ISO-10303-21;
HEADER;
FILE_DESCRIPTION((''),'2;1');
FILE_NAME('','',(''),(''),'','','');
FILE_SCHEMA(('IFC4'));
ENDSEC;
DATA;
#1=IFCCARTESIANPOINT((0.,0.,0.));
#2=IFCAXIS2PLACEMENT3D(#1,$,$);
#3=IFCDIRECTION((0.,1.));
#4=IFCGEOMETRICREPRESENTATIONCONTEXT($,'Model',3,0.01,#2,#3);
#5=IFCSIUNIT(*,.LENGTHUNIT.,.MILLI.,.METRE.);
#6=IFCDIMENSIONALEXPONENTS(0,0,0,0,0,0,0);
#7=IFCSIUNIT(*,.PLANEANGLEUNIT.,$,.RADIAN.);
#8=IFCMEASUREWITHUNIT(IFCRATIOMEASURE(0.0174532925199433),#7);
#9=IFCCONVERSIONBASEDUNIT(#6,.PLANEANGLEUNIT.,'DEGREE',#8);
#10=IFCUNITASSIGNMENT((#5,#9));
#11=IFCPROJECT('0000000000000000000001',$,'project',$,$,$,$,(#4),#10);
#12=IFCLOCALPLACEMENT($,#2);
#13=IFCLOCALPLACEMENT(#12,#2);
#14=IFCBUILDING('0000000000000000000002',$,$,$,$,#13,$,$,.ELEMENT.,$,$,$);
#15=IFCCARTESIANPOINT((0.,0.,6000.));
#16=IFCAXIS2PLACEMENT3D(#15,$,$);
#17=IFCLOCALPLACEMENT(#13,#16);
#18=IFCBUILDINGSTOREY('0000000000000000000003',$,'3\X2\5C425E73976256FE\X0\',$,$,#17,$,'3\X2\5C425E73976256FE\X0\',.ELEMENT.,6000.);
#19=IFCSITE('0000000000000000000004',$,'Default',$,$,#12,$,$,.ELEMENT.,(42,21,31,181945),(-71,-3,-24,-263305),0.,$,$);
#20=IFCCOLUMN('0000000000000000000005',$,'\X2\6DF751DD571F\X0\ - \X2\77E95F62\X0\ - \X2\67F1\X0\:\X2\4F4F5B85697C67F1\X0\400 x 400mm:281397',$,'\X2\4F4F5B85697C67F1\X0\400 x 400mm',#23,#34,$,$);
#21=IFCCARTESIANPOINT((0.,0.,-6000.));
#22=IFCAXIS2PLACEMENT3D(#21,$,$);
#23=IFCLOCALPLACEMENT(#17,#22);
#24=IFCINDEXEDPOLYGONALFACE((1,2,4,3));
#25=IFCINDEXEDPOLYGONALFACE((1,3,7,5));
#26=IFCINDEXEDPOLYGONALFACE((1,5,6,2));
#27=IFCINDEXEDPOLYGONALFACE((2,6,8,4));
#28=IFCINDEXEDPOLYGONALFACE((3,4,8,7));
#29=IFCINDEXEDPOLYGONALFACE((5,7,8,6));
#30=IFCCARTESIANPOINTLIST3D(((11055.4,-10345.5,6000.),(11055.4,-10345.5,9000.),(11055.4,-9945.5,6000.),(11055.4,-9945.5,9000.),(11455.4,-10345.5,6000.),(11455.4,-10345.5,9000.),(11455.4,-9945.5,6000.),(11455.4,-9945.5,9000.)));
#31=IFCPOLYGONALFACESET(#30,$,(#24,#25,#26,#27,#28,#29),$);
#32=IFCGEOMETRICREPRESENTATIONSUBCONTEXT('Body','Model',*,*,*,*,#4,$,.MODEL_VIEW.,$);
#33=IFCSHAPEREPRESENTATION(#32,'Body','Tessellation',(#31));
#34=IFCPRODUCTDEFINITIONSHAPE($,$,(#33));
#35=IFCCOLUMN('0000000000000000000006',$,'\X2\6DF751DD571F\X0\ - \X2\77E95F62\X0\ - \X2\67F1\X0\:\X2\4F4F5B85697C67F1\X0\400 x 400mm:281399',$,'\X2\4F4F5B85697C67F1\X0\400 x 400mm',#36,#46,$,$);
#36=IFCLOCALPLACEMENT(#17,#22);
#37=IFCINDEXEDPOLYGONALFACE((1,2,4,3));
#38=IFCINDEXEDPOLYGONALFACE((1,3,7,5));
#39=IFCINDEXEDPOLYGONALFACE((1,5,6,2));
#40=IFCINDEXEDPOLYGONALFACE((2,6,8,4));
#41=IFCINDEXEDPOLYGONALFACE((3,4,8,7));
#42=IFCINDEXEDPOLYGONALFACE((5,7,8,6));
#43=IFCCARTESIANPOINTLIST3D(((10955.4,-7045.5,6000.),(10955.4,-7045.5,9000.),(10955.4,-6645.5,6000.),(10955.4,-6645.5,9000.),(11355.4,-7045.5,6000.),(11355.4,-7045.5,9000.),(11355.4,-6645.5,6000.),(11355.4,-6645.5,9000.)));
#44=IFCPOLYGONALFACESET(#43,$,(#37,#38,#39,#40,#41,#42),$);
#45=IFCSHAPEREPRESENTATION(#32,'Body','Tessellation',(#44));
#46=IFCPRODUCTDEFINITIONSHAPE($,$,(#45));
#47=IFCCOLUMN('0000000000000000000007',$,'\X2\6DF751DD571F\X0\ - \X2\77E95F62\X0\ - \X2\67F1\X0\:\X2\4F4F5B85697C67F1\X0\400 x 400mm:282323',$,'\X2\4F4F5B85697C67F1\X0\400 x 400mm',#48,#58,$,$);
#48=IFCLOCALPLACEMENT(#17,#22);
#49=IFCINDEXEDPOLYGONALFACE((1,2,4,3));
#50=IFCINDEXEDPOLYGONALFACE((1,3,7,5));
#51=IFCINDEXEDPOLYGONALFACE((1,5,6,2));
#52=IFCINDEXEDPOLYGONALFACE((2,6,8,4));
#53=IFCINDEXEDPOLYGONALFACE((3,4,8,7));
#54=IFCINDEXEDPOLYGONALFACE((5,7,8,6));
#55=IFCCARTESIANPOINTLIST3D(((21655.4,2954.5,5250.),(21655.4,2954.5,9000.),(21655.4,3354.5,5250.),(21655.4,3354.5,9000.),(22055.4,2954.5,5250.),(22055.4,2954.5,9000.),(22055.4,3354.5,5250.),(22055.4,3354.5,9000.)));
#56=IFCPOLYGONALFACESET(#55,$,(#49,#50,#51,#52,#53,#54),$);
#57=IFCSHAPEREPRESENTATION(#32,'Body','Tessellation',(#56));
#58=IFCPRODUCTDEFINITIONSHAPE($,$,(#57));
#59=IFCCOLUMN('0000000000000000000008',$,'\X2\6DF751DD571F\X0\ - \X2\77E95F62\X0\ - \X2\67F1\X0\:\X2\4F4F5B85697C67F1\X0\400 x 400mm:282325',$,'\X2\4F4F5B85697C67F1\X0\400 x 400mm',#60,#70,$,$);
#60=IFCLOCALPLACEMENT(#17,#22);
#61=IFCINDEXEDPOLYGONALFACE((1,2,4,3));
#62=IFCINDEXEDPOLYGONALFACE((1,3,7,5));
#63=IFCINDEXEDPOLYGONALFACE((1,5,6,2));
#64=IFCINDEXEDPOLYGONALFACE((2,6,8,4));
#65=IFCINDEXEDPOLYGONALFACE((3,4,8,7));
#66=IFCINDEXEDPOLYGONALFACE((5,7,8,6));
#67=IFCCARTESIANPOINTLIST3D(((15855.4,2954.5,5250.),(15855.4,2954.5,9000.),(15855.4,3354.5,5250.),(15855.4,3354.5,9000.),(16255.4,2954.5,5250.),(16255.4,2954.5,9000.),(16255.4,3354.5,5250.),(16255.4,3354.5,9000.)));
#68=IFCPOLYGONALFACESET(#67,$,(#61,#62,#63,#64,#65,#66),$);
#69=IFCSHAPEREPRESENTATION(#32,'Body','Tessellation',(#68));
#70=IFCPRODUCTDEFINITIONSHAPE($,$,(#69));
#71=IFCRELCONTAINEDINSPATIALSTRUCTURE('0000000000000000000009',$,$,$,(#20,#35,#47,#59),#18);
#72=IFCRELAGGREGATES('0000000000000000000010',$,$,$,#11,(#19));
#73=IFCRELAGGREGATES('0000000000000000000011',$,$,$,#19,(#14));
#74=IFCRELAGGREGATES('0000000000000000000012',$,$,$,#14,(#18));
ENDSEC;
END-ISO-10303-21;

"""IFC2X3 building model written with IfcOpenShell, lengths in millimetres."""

from ifc_helpers import new_model, entity, si_unit, converted_unit, direction, frame, frame_2d, origin, origin_2d_with_axis, place, context, subcontext, project, spatial, rectangle, extrude, source, transform, mapped, element, save


model = new_model("IFC2X3")

# Units and contexts
model_context = context("Model", 3, precision=0.01, world=origin(), true_north=direction((0.0, 1.0)))
body_context = subcontext(model_context, "Body", "Model", "MODEL_VIEW")
ifc_project = project(units=[si_unit("LENGTHUNIT", "METRE", prefix="MILLI"), converted_unit("PLANEANGLEUNIT", "DEGREE", entity("IfcRatioMeasure", 0.0174532925199433), si_unit("PLANEANGLEUNIT", "RADIAN"), dimensions=[0, 0, 0, 0, 0, 0, 0])], contexts=[model_context])

# Site, building, storey
site_placement = place(None, origin())
site = spatial("IfcSite", under=ifc_project, at=site_placement, Name="Default", CompositionType="ELEMENT", RefLatitude=(42, 21, 31, 181945), RefLongitude=(-71, -3, -24, -263305), RefElevation=0.0)
building_placement = place(site_placement, origin())
building = spatial("IfcBuilding", under=site, at=building_placement, CompositionType="ELEMENT")
storey_placement = place(building_placement, frame((0.0, 0.0, 6000.0)))
storey = spatial("IfcBuildingStorey", under=building, at=storey_placement, Name="3层平面图", LongName="3层平面图", CompositionType="ELEMENT", Elevation=6000.0)

# Columns
shared_shape_1 = source(origin(), body_context, "Body", "SweptSolid", [
    extrude(rectangle(XDim=400.0, YDim=400.0, at=origin_2d_with_axis()), frame((11255.4, -10145.5, 6000.0), z_axis=(0.0, 0.0, 1.0), x_axis=(0.0, -1.0, 0.0)), (0.0, 0.0, 1.0), 3000.0),
])
column_1_placement = place(storey_placement, frame((0.0, 0.0, -6000.0)))
element("IfcColumn", 1, at=column_1_placement, inside=storey, Name="混凝土 - 矩形 - 柱:住宅楼柱400 x 400mm:281397", ObjectType="住宅楼柱400 x 400mm", context=body_context, shape_type="MappedRepresentation", body=[
    mapped(shared_shape_1, transform((0.0, 0.0, 0.0), scale=1.0)),
])
shared_shape_2 = source(origin(), body_context, "Body", "SweptSolid", [
    extrude(rectangle(XDim=400.0, YDim=400.0, at=origin_2d_with_axis()), frame((11155.4, -6845.5, 6000.0), z_axis=(0.0, 0.0, 1.0), x_axis=(0.0, -1.0, 0.0)), (0.0, 0.0, 1.0), 3000.0),
])
column_2_placement = place(storey_placement, frame((0.0, 0.0, -6000.0)))
element("IfcColumn", 2, at=column_2_placement, inside=storey, Name="混凝土 - 矩形 - 柱:住宅楼柱400 x 400mm:281399", ObjectType="住宅楼柱400 x 400mm", context=body_context, shape_type="MappedRepresentation", body=[
    mapped(shared_shape_2, transform((0.0, 0.0, 0.0), scale=1.0)),
])
shared_shape_3 = source(origin(), body_context, "Body", "SweptSolid", [
    extrude(rectangle(XDim=400.0, YDim=400.0, at=frame_2d((0.0, 0.0), x_axis=(1.0, 0.0))), frame((21855.4, 3154.5, 5250.0), z_axis=(0.0, 0.0, 1.0), x_axis=(0.0, -1.0, 0.0)), (0.0, 0.0, 1.0), 3750.0),
])
column_3_placement = place(storey_placement, frame((0.0, 0.0, -6000.0)))
element("IfcColumn", 3, at=column_3_placement, inside=storey, Name="混凝土 - 矩形 - 柱:住宅楼柱400 x 400mm:282323", ObjectType="住宅楼柱400 x 400mm", context=body_context, shape_type="MappedRepresentation", body=[
    mapped(shared_shape_3, transform((0.0, 0.0, 0.0), scale=1.0)),
])
shared_shape_4 = source(origin(), body_context, "Body", "SweptSolid", [
    extrude(rectangle(XDim=400.0, YDim=400.0, at=origin_2d_with_axis()), frame((16055.4, 3154.5, 5250.0), z_axis=(0.0, 0.0, 1.0), x_axis=(0.0, -1.0, 0.0)), (0.0, 0.0, 1.0), 3750.0),
])
column_4_placement = place(storey_placement, frame((0.0, 0.0, -6000.0)))
element("IfcColumn", 4, at=column_4_placement, inside=storey, Name="混凝土 - 矩形 - 柱:住宅楼柱400 x 400mm:282325", ObjectType="住宅楼柱400 x 400mm", context=body_context, shape_type="MappedRepresentation", body=[
    mapped(shared_shape_4, transform((0.0, 0.0, 0.0), scale=1.0)),
])

save(model, "model.ifc")
